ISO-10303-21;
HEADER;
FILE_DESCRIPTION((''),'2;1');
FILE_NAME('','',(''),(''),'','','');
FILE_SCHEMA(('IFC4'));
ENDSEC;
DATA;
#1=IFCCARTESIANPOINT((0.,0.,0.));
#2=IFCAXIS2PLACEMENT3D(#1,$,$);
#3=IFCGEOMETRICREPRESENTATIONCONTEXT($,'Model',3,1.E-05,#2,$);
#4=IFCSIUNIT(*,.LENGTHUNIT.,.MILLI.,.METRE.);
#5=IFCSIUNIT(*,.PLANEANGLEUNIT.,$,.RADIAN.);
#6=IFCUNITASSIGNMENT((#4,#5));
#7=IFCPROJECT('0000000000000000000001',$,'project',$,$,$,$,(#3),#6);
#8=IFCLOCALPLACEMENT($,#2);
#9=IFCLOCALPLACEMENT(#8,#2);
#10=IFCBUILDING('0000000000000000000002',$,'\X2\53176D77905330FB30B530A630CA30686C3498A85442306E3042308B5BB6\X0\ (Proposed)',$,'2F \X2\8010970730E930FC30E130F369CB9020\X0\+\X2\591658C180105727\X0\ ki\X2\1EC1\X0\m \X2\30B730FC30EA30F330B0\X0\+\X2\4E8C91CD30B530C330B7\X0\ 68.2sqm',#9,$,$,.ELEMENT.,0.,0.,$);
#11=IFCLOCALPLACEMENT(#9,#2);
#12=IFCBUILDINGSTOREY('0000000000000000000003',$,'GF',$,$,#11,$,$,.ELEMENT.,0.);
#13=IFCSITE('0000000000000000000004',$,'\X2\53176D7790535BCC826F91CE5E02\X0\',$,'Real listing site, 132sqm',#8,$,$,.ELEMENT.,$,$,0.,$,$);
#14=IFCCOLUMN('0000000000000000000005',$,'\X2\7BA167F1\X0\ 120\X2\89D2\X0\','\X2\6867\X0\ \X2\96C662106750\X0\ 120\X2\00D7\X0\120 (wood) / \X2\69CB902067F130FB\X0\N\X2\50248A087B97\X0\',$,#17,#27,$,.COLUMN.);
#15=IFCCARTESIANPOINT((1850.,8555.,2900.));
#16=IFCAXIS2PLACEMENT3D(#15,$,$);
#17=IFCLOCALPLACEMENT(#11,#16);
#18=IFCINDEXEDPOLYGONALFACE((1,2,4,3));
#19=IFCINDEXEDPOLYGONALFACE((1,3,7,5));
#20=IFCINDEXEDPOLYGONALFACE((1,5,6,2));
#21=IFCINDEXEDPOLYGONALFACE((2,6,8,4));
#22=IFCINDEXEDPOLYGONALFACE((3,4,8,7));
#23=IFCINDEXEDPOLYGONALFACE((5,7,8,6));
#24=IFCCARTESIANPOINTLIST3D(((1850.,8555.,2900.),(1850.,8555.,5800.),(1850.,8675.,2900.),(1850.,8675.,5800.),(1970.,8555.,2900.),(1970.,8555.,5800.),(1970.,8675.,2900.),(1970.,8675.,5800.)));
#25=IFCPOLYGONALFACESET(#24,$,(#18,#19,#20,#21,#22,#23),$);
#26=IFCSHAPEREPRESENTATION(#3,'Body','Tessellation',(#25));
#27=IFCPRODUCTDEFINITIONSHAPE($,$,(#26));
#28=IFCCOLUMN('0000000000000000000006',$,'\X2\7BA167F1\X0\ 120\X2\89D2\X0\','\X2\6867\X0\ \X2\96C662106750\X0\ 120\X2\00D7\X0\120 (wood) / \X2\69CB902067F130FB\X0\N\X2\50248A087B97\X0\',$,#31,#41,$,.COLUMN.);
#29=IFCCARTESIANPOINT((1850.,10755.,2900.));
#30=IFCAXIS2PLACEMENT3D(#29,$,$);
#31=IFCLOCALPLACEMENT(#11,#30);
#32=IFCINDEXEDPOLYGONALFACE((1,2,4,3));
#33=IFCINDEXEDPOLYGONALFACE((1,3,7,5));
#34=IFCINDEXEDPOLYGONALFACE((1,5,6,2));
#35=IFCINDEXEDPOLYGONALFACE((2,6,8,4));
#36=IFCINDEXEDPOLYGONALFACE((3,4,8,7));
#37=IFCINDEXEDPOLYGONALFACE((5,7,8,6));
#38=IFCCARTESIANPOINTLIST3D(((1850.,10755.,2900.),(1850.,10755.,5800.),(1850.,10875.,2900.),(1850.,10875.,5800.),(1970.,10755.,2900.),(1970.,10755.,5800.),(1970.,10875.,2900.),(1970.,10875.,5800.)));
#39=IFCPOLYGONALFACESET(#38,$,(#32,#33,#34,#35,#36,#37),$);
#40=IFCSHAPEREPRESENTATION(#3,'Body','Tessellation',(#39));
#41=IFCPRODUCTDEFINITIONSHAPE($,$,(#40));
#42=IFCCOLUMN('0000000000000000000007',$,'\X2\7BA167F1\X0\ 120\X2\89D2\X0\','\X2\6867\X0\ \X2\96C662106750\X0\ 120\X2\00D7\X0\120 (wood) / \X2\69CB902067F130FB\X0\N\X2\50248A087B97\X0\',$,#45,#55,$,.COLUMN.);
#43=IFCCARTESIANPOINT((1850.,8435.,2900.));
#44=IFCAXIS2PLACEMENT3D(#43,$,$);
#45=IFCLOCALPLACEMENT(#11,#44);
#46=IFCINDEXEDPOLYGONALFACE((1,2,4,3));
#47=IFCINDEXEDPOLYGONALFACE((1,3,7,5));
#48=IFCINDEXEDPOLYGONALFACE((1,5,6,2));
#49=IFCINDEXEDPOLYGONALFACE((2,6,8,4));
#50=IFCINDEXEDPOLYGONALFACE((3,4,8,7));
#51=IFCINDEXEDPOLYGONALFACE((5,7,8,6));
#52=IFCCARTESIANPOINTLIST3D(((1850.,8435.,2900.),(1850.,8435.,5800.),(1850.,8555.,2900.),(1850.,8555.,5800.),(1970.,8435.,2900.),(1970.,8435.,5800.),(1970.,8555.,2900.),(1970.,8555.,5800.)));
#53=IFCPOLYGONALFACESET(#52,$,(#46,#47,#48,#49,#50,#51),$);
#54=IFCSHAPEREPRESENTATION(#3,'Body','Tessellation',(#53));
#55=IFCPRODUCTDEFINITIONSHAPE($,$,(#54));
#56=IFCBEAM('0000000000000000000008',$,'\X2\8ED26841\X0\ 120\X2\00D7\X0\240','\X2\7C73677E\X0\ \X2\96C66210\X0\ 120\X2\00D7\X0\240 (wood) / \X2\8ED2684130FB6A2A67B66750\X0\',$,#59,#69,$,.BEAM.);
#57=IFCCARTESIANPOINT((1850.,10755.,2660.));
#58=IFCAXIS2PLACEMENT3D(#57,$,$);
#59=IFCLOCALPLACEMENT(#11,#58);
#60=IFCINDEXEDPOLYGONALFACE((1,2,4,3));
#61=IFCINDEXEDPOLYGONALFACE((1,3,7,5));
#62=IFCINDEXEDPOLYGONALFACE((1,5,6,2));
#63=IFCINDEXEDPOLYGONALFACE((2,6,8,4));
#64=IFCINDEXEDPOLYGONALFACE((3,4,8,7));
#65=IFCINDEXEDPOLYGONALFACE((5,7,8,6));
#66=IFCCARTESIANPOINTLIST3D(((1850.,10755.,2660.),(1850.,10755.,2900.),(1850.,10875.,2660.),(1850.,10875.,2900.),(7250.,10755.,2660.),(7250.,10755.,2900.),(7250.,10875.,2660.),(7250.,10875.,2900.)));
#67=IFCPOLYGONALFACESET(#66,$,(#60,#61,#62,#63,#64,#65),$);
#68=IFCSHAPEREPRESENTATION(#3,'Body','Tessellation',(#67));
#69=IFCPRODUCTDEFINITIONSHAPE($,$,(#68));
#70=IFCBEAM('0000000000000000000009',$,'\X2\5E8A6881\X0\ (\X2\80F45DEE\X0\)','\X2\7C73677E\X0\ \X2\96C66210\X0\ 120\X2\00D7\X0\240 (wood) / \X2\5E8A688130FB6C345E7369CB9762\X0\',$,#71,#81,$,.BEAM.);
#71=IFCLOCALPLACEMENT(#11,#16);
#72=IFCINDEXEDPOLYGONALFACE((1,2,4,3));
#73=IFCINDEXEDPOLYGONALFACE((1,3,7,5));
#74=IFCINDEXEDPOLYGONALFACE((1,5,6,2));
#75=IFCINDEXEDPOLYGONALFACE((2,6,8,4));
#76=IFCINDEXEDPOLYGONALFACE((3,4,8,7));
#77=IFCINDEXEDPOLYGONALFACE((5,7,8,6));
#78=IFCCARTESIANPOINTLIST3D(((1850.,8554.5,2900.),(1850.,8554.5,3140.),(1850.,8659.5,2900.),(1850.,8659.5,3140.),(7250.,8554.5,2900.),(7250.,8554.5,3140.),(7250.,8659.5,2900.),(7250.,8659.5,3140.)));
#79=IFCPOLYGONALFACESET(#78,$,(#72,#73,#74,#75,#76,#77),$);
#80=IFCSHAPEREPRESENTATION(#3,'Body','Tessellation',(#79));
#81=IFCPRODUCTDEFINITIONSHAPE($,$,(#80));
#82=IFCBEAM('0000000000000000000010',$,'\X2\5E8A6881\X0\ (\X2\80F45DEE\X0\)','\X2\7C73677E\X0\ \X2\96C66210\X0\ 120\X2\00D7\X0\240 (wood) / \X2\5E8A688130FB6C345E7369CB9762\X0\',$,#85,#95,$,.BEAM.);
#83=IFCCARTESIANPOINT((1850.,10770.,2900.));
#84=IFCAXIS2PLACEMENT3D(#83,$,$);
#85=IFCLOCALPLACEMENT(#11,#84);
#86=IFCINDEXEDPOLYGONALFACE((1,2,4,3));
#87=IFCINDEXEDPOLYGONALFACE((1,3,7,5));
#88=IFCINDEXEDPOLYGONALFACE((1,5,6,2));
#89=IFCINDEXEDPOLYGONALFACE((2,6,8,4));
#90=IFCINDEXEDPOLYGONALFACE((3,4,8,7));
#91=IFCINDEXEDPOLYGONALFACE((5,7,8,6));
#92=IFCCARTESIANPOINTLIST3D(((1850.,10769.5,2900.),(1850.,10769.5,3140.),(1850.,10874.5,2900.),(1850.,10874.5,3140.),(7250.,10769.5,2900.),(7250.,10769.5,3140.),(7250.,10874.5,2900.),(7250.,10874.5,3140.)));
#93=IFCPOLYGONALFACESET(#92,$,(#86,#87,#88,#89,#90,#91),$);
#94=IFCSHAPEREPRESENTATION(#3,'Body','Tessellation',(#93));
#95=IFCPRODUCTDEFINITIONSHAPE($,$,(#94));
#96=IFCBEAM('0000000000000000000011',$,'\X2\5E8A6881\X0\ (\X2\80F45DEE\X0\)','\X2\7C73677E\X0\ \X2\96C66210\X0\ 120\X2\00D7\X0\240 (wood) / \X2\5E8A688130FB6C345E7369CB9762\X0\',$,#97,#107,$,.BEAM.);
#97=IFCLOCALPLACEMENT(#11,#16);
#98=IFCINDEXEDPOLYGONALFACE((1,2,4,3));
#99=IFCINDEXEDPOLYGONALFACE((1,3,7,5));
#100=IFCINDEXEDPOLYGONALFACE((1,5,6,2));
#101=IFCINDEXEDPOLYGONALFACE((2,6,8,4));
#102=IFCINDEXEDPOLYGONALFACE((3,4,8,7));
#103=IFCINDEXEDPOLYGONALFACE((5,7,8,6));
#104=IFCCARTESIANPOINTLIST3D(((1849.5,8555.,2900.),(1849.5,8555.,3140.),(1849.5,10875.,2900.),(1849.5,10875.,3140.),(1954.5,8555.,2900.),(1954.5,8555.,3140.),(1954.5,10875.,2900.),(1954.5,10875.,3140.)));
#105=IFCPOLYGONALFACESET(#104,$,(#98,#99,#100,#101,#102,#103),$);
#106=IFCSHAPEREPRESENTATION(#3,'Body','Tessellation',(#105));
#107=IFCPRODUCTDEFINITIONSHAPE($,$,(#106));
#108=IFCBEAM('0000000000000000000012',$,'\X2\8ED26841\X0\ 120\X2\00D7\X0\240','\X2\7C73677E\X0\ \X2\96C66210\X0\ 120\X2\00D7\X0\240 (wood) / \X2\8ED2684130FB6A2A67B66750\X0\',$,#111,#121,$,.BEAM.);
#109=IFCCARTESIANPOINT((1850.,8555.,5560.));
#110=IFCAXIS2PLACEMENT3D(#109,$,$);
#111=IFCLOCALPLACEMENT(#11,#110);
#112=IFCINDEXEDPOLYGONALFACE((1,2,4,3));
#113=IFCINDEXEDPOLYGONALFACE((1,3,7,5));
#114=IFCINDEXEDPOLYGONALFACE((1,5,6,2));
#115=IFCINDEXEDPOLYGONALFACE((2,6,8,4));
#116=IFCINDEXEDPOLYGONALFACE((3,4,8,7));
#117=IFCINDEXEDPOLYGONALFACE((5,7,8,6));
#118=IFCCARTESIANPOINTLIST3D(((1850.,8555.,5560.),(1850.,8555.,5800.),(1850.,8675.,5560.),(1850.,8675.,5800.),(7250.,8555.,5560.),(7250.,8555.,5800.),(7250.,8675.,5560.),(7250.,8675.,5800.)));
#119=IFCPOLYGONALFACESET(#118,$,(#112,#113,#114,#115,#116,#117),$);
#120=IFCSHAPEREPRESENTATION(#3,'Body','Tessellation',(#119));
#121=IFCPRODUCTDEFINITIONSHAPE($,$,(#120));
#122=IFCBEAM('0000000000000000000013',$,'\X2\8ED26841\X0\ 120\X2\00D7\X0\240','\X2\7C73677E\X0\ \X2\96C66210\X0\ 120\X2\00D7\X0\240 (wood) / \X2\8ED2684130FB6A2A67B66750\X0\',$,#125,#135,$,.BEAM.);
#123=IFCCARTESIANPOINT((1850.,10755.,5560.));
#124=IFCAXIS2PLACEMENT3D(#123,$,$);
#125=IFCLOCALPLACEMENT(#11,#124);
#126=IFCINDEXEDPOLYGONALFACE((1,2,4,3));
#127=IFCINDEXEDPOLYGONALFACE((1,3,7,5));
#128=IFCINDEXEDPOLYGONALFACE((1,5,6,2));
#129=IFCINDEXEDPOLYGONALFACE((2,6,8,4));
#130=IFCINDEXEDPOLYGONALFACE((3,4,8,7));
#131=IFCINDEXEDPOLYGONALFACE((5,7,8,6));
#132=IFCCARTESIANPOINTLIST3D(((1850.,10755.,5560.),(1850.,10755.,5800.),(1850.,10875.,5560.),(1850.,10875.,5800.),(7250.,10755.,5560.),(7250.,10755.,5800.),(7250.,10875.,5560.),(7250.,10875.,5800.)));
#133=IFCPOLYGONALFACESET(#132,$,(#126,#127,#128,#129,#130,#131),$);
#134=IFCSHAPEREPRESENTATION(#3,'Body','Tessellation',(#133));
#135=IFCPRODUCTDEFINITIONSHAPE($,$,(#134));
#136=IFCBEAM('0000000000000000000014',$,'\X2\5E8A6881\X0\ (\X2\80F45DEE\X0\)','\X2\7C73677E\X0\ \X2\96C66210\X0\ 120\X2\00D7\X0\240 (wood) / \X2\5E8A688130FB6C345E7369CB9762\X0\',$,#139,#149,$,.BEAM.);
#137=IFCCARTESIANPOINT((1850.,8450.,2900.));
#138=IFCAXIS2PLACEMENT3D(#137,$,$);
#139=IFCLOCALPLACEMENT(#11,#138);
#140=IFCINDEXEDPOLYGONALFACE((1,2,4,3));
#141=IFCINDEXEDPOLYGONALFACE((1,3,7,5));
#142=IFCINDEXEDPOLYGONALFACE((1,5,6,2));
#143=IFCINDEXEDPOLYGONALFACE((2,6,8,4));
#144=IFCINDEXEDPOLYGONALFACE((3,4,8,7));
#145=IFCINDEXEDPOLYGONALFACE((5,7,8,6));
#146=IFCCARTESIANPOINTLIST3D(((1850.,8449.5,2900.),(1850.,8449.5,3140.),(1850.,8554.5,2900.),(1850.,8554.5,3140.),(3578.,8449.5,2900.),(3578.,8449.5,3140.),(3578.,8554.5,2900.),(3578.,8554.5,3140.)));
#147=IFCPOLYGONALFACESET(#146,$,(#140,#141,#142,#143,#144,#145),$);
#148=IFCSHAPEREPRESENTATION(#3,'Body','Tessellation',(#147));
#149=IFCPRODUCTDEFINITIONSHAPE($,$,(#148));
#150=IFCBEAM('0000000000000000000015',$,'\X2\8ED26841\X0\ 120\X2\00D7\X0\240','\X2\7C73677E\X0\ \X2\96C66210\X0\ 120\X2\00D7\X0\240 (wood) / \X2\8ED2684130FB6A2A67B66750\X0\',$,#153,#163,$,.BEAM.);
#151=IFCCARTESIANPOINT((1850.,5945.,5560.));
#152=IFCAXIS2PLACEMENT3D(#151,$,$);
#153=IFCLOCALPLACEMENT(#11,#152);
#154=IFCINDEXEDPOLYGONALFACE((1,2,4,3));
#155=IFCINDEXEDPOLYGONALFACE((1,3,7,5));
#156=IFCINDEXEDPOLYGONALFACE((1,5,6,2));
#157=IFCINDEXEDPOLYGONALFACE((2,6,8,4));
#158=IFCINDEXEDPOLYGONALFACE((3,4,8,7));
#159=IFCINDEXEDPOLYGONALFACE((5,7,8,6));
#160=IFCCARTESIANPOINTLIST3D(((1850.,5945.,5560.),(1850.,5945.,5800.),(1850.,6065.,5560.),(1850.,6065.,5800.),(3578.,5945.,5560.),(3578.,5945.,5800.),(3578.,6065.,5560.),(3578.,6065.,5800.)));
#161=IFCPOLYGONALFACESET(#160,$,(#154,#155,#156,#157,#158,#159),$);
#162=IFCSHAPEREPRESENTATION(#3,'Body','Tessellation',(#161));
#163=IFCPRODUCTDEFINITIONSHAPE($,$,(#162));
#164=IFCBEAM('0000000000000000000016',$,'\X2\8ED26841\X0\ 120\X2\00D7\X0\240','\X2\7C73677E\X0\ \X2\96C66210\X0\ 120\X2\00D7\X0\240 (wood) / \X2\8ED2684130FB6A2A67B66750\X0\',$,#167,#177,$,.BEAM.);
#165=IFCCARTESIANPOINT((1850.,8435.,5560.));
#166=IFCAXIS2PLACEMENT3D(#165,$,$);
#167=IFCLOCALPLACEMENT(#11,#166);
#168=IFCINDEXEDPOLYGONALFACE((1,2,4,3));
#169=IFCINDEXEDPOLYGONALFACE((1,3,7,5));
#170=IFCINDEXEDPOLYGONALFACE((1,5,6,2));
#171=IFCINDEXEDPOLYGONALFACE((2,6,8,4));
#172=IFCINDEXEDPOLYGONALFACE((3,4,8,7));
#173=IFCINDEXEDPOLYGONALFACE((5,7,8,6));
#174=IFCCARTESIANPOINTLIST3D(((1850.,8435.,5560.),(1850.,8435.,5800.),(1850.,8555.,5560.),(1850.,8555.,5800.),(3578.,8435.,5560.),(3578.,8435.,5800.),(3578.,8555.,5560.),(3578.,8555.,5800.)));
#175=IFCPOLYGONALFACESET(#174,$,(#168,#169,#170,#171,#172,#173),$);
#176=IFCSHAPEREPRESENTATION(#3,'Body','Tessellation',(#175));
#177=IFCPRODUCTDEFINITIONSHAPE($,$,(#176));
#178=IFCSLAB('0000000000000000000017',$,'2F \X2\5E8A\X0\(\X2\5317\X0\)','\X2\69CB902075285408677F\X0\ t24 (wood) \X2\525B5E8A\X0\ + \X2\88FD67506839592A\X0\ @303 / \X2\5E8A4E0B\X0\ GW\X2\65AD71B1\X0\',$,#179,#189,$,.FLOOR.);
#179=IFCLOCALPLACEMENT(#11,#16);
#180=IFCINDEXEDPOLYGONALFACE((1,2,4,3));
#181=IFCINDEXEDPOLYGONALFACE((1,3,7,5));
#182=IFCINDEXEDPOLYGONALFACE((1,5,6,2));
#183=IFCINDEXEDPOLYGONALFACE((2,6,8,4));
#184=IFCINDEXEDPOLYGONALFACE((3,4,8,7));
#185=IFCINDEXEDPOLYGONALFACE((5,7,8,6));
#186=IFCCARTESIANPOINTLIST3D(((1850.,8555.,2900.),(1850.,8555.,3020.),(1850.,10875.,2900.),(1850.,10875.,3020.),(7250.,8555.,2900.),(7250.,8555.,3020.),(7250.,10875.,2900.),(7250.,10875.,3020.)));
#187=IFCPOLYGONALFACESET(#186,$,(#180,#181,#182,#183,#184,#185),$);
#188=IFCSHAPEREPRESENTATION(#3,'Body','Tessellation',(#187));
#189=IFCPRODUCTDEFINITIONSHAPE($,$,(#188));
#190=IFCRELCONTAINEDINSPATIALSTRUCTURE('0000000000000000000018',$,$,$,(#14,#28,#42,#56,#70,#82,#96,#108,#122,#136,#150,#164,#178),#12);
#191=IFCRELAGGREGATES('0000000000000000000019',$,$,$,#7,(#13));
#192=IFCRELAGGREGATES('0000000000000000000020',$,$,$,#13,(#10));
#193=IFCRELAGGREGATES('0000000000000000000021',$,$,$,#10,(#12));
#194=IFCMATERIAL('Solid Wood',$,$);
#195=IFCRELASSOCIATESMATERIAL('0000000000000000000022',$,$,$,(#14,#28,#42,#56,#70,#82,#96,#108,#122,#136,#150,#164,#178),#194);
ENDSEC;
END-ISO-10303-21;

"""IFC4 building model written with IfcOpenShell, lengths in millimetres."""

from ifc_helpers import new_model, si_unit, frame, frame_2d, origin, place, context, project, spatial, rectangle, extrude, material, element, save


model = new_model("IFC4")

# Units and contexts
model_context = context("Model", 3, precision=1e-05, world=origin())
ifc_project = project(units=[si_unit("LENGTHUNIT", "METRE", prefix="MILLI"), si_unit("PLANEANGLEUNIT", "RADIAN")], contexts=[model_context])

# Site, building, storey
site_placement = place(None, origin())
site = spatial("IfcSite", under=ifc_project, at=site_placement, Name="北海道富良野市", ObjectType="Real listing site, 132sqm", CompositionType="ELEMENT", RefElevation=0.0)
building_placement = place(site_placement, origin())
building = spatial("IfcBuilding", under=site, at=building_placement, Name="北海道・サウナと水風呂のある家 (Proposed)", ObjectType="2F 耐震ラーメン構造+外壁耐圧 kiềm シーリング+二重サッシ 68.2sqm", CompositionType="ELEMENT", ElevationOfRefHeight=0.0, ElevationOfTerrain=0.0)
storey_placement = place(building_placement, origin())
storey = spatial("IfcBuildingStorey", under=building, at=storey_placement, Name="GF", CompositionType="ELEMENT", Elevation=0.0)

# Columns
ifc_material_1 = material(Name="Solid Wood")
column_1_placement = place(storey_placement, frame((1850.0, 8555.0, 2900.0)))
element("IfcColumn", 1, at=column_1_placement, inside=storey, material=ifc_material_1, Name="管柱 120角", Description="桧 集成材 120×120 (wood) / 構造柱・N値計算", PredefinedType="COLUMN", context=model_context, shape_type="SweptSolid", body=[
    extrude(rectangle(XDim=120.0, YDim=120.0, at=frame_2d((60.0, 60.0))), frame((1850.0, 8555.0, 2900.0)), (0.0, 0.0, 1.0), 2900.0),
])
column_2_placement = place(storey_placement, frame((1850.0, 10755.0, 2900.0)))
element("IfcColumn", 2, at=column_2_placement, inside=storey, material=ifc_material_1, Name="管柱 120角", Description="桧 集成材 120×120 (wood) / 構造柱・N値計算", PredefinedType="COLUMN", context=model_context, shape_type="SweptSolid", body=[
    extrude(rectangle(XDim=120.0, YDim=120.0, at=frame_2d((60.0, 60.0))), frame((1850.0, 10755.0, 2900.0)), (0.0, 0.0, 1.0), 2900.0),
])
column_3_placement = place(storey_placement, frame((1850.0, 8435.0, 2900.0)))
element("IfcColumn", 3, at=column_3_placement, inside=storey, material=ifc_material_1, Name="管柱 120角", Description="桧 集成材 120×120 (wood) / 構造柱・N値計算", PredefinedType="COLUMN", context=model_context, shape_type="SweptSolid", body=[
    extrude(rectangle(XDim=120.0, YDim=120.0, at=frame_2d((60.0, 60.0))), frame((1850.0, 8435.0, 2900.0)), (0.0, 0.0, 1.0), 2900.0),
])

# Beams
beam_1_placement = place(storey_placement, frame((1850.0, 10755.0, 2660.0)))
element("IfcBeam", 4, at=beam_1_placement, inside=storey, material=ifc_material_1, Name="軒桁 120×240", Description="米松 集成 120×240 (wood) / 軒桁・横架材", PredefinedType="BEAM", context=model_context, shape_type="SweptSolid", body=[
    extrude(rectangle(XDim=5400.0, YDim=120.0, at=frame_2d((2700.0, 60.0))), frame((1850.0, 10755.0, 2660.0)), (0.0, 0.0, 1.0), 240.0),
])
beam_2_placement = place(storey_placement, frame((1850.0, 8555.0, 2900.0)))
element("IfcBeam", 5, at=beam_2_placement, inside=storey, material=ifc_material_1, Name="床梁 (胴差)", Description="米松 集成 120×240 (wood) / 床梁・水平構面", PredefinedType="BEAM", context=model_context, shape_type="SweptSolid", body=[
    extrude(rectangle(XDim=5400.0, YDim=105.0, at=frame_2d((2700.0, 52.0))), frame((1850.0, 8555.0, 2900.0)), (0.0, 0.0, 1.0), 240.0),
])
beam_3_placement = place(storey_placement, frame((1850.0, 10770.0, 2900.0)))
element("IfcBeam", 6, at=beam_3_placement, inside=storey, material=ifc_material_1, Name="床梁 (胴差)", Description="米松 集成 120×240 (wood) / 床梁・水平構面", PredefinedType="BEAM", context=model_context, shape_type="SweptSolid", body=[
    extrude(rectangle(XDim=5400.0, YDim=105.0, at=frame_2d((2700.0, 52.0))), frame((1850.0, 10770.0, 2900.0)), (0.0, 0.0, 1.0), 240.0),
])
beam_4_placement = place(storey_placement, frame((1850.0, 8555.0, 2900.0)))
element("IfcBeam", 7, at=beam_4_placement, inside=storey, material=ifc_material_1, Name="床梁 (胴差)", Description="米松 集成 120×240 (wood) / 床梁・水平構面", PredefinedType="BEAM", context=model_context, shape_type="SweptSolid", body=[
    extrude(rectangle(XDim=105.0, YDim=2320.0, at=frame_2d((52.0, 1160.0))), frame((1850.0, 8555.0, 2900.0)), (0.0, 0.0, 1.0), 240.0),
])
beam_5_placement = place(storey_placement, frame((1850.0, 8555.0, 5560.0)))
element("IfcBeam", 8, at=beam_5_placement, inside=storey, material=ifc_material_1, Name="軒桁 120×240", Description="米松 集成 120×240 (wood) / 軒桁・横架材", PredefinedType="BEAM", context=model_context, shape_type="SweptSolid", body=[
    extrude(rectangle(XDim=5400.0, YDim=120.0, at=frame_2d((2700.0, 60.0))), frame((1850.0, 8555.0, 5560.0)), (0.0, 0.0, 1.0), 240.0),
])
beam_6_placement = place(storey_placement, frame((1850.0, 10755.0, 5560.0)))
element("IfcBeam", 9, at=beam_6_placement, inside=storey, material=ifc_material_1, Name="軒桁 120×240", Description="米松 集成 120×240 (wood) / 軒桁・横架材", PredefinedType="BEAM", context=model_context, shape_type="SweptSolid", body=[
    extrude(rectangle(XDim=5400.0, YDim=120.0, at=frame_2d((2700.0, 60.0))), frame((1850.0, 10755.0, 5560.0)), (0.0, 0.0, 1.0), 240.0),
])
beam_7_placement = place(storey_placement, frame((1850.0, 8450.0, 2900.0)))
element("IfcBeam", 10, at=beam_7_placement, inside=storey, material=ifc_material_1, Name="床梁 (胴差)", Description="米松 集成 120×240 (wood) / 床梁・水平構面", PredefinedType="BEAM", context=model_context, shape_type="SweptSolid", body=[
    extrude(rectangle(XDim=1728.0, YDim=105.0, at=frame_2d((864.0, 52.0))), frame((1850.0, 8450.0, 2900.0)), (0.0, 0.0, 1.0), 240.0),
])
beam_8_placement = place(storey_placement, frame((1850.0, 5945.0, 5560.0)))
element("IfcBeam", 11, at=beam_8_placement, inside=storey, material=ifc_material_1, Name="軒桁 120×240", Description="米松 集成 120×240 (wood) / 軒桁・横架材", PredefinedType="BEAM", context=model_context, shape_type="SweptSolid", body=[
    extrude(rectangle(XDim=1728.0, YDim=120.0, at=frame_2d((864.0, 60.0))), frame((1850.0, 5945.0, 5560.0)), (0.0, 0.0, 1.0), 240.0),
])
beam_9_placement = place(storey_placement, frame((1850.0, 8435.0, 5560.0)))
element("IfcBeam", 12, at=beam_9_placement, inside=storey, material=ifc_material_1, Name="軒桁 120×240", Description="米松 集成 120×240 (wood) / 軒桁・横架材", PredefinedType="BEAM", context=model_context, shape_type="SweptSolid", body=[
    extrude(rectangle(XDim=1728.0, YDim=120.0, at=frame_2d((864.0, 60.0))), frame((1850.0, 8435.0, 5560.0)), (0.0, 0.0, 1.0), 240.0),
])

# Slab
slab_placement = place(storey_placement, frame((1850.0, 8555.0, 2900.0)))
element("IfcSlab", 13, at=slab_placement, inside=storey, material=ifc_material_1, Name="2F 床(北)", Description="構造用合板 t24 (wood) 剛床 + 製材根太 @303 / 床下 GW断熱", PredefinedType="FLOOR", context=model_context, shape_type="SweptSolid", body=[
    extrude(rectangle(XDim=5400.0, YDim=2320.0, at=frame_2d((2700.0, 1160.0))), frame((1850.0, 8555.0, 2900.0)), (0.0, 0.0, 1.0), 120.0),
])

save(model, "model.ifc")
